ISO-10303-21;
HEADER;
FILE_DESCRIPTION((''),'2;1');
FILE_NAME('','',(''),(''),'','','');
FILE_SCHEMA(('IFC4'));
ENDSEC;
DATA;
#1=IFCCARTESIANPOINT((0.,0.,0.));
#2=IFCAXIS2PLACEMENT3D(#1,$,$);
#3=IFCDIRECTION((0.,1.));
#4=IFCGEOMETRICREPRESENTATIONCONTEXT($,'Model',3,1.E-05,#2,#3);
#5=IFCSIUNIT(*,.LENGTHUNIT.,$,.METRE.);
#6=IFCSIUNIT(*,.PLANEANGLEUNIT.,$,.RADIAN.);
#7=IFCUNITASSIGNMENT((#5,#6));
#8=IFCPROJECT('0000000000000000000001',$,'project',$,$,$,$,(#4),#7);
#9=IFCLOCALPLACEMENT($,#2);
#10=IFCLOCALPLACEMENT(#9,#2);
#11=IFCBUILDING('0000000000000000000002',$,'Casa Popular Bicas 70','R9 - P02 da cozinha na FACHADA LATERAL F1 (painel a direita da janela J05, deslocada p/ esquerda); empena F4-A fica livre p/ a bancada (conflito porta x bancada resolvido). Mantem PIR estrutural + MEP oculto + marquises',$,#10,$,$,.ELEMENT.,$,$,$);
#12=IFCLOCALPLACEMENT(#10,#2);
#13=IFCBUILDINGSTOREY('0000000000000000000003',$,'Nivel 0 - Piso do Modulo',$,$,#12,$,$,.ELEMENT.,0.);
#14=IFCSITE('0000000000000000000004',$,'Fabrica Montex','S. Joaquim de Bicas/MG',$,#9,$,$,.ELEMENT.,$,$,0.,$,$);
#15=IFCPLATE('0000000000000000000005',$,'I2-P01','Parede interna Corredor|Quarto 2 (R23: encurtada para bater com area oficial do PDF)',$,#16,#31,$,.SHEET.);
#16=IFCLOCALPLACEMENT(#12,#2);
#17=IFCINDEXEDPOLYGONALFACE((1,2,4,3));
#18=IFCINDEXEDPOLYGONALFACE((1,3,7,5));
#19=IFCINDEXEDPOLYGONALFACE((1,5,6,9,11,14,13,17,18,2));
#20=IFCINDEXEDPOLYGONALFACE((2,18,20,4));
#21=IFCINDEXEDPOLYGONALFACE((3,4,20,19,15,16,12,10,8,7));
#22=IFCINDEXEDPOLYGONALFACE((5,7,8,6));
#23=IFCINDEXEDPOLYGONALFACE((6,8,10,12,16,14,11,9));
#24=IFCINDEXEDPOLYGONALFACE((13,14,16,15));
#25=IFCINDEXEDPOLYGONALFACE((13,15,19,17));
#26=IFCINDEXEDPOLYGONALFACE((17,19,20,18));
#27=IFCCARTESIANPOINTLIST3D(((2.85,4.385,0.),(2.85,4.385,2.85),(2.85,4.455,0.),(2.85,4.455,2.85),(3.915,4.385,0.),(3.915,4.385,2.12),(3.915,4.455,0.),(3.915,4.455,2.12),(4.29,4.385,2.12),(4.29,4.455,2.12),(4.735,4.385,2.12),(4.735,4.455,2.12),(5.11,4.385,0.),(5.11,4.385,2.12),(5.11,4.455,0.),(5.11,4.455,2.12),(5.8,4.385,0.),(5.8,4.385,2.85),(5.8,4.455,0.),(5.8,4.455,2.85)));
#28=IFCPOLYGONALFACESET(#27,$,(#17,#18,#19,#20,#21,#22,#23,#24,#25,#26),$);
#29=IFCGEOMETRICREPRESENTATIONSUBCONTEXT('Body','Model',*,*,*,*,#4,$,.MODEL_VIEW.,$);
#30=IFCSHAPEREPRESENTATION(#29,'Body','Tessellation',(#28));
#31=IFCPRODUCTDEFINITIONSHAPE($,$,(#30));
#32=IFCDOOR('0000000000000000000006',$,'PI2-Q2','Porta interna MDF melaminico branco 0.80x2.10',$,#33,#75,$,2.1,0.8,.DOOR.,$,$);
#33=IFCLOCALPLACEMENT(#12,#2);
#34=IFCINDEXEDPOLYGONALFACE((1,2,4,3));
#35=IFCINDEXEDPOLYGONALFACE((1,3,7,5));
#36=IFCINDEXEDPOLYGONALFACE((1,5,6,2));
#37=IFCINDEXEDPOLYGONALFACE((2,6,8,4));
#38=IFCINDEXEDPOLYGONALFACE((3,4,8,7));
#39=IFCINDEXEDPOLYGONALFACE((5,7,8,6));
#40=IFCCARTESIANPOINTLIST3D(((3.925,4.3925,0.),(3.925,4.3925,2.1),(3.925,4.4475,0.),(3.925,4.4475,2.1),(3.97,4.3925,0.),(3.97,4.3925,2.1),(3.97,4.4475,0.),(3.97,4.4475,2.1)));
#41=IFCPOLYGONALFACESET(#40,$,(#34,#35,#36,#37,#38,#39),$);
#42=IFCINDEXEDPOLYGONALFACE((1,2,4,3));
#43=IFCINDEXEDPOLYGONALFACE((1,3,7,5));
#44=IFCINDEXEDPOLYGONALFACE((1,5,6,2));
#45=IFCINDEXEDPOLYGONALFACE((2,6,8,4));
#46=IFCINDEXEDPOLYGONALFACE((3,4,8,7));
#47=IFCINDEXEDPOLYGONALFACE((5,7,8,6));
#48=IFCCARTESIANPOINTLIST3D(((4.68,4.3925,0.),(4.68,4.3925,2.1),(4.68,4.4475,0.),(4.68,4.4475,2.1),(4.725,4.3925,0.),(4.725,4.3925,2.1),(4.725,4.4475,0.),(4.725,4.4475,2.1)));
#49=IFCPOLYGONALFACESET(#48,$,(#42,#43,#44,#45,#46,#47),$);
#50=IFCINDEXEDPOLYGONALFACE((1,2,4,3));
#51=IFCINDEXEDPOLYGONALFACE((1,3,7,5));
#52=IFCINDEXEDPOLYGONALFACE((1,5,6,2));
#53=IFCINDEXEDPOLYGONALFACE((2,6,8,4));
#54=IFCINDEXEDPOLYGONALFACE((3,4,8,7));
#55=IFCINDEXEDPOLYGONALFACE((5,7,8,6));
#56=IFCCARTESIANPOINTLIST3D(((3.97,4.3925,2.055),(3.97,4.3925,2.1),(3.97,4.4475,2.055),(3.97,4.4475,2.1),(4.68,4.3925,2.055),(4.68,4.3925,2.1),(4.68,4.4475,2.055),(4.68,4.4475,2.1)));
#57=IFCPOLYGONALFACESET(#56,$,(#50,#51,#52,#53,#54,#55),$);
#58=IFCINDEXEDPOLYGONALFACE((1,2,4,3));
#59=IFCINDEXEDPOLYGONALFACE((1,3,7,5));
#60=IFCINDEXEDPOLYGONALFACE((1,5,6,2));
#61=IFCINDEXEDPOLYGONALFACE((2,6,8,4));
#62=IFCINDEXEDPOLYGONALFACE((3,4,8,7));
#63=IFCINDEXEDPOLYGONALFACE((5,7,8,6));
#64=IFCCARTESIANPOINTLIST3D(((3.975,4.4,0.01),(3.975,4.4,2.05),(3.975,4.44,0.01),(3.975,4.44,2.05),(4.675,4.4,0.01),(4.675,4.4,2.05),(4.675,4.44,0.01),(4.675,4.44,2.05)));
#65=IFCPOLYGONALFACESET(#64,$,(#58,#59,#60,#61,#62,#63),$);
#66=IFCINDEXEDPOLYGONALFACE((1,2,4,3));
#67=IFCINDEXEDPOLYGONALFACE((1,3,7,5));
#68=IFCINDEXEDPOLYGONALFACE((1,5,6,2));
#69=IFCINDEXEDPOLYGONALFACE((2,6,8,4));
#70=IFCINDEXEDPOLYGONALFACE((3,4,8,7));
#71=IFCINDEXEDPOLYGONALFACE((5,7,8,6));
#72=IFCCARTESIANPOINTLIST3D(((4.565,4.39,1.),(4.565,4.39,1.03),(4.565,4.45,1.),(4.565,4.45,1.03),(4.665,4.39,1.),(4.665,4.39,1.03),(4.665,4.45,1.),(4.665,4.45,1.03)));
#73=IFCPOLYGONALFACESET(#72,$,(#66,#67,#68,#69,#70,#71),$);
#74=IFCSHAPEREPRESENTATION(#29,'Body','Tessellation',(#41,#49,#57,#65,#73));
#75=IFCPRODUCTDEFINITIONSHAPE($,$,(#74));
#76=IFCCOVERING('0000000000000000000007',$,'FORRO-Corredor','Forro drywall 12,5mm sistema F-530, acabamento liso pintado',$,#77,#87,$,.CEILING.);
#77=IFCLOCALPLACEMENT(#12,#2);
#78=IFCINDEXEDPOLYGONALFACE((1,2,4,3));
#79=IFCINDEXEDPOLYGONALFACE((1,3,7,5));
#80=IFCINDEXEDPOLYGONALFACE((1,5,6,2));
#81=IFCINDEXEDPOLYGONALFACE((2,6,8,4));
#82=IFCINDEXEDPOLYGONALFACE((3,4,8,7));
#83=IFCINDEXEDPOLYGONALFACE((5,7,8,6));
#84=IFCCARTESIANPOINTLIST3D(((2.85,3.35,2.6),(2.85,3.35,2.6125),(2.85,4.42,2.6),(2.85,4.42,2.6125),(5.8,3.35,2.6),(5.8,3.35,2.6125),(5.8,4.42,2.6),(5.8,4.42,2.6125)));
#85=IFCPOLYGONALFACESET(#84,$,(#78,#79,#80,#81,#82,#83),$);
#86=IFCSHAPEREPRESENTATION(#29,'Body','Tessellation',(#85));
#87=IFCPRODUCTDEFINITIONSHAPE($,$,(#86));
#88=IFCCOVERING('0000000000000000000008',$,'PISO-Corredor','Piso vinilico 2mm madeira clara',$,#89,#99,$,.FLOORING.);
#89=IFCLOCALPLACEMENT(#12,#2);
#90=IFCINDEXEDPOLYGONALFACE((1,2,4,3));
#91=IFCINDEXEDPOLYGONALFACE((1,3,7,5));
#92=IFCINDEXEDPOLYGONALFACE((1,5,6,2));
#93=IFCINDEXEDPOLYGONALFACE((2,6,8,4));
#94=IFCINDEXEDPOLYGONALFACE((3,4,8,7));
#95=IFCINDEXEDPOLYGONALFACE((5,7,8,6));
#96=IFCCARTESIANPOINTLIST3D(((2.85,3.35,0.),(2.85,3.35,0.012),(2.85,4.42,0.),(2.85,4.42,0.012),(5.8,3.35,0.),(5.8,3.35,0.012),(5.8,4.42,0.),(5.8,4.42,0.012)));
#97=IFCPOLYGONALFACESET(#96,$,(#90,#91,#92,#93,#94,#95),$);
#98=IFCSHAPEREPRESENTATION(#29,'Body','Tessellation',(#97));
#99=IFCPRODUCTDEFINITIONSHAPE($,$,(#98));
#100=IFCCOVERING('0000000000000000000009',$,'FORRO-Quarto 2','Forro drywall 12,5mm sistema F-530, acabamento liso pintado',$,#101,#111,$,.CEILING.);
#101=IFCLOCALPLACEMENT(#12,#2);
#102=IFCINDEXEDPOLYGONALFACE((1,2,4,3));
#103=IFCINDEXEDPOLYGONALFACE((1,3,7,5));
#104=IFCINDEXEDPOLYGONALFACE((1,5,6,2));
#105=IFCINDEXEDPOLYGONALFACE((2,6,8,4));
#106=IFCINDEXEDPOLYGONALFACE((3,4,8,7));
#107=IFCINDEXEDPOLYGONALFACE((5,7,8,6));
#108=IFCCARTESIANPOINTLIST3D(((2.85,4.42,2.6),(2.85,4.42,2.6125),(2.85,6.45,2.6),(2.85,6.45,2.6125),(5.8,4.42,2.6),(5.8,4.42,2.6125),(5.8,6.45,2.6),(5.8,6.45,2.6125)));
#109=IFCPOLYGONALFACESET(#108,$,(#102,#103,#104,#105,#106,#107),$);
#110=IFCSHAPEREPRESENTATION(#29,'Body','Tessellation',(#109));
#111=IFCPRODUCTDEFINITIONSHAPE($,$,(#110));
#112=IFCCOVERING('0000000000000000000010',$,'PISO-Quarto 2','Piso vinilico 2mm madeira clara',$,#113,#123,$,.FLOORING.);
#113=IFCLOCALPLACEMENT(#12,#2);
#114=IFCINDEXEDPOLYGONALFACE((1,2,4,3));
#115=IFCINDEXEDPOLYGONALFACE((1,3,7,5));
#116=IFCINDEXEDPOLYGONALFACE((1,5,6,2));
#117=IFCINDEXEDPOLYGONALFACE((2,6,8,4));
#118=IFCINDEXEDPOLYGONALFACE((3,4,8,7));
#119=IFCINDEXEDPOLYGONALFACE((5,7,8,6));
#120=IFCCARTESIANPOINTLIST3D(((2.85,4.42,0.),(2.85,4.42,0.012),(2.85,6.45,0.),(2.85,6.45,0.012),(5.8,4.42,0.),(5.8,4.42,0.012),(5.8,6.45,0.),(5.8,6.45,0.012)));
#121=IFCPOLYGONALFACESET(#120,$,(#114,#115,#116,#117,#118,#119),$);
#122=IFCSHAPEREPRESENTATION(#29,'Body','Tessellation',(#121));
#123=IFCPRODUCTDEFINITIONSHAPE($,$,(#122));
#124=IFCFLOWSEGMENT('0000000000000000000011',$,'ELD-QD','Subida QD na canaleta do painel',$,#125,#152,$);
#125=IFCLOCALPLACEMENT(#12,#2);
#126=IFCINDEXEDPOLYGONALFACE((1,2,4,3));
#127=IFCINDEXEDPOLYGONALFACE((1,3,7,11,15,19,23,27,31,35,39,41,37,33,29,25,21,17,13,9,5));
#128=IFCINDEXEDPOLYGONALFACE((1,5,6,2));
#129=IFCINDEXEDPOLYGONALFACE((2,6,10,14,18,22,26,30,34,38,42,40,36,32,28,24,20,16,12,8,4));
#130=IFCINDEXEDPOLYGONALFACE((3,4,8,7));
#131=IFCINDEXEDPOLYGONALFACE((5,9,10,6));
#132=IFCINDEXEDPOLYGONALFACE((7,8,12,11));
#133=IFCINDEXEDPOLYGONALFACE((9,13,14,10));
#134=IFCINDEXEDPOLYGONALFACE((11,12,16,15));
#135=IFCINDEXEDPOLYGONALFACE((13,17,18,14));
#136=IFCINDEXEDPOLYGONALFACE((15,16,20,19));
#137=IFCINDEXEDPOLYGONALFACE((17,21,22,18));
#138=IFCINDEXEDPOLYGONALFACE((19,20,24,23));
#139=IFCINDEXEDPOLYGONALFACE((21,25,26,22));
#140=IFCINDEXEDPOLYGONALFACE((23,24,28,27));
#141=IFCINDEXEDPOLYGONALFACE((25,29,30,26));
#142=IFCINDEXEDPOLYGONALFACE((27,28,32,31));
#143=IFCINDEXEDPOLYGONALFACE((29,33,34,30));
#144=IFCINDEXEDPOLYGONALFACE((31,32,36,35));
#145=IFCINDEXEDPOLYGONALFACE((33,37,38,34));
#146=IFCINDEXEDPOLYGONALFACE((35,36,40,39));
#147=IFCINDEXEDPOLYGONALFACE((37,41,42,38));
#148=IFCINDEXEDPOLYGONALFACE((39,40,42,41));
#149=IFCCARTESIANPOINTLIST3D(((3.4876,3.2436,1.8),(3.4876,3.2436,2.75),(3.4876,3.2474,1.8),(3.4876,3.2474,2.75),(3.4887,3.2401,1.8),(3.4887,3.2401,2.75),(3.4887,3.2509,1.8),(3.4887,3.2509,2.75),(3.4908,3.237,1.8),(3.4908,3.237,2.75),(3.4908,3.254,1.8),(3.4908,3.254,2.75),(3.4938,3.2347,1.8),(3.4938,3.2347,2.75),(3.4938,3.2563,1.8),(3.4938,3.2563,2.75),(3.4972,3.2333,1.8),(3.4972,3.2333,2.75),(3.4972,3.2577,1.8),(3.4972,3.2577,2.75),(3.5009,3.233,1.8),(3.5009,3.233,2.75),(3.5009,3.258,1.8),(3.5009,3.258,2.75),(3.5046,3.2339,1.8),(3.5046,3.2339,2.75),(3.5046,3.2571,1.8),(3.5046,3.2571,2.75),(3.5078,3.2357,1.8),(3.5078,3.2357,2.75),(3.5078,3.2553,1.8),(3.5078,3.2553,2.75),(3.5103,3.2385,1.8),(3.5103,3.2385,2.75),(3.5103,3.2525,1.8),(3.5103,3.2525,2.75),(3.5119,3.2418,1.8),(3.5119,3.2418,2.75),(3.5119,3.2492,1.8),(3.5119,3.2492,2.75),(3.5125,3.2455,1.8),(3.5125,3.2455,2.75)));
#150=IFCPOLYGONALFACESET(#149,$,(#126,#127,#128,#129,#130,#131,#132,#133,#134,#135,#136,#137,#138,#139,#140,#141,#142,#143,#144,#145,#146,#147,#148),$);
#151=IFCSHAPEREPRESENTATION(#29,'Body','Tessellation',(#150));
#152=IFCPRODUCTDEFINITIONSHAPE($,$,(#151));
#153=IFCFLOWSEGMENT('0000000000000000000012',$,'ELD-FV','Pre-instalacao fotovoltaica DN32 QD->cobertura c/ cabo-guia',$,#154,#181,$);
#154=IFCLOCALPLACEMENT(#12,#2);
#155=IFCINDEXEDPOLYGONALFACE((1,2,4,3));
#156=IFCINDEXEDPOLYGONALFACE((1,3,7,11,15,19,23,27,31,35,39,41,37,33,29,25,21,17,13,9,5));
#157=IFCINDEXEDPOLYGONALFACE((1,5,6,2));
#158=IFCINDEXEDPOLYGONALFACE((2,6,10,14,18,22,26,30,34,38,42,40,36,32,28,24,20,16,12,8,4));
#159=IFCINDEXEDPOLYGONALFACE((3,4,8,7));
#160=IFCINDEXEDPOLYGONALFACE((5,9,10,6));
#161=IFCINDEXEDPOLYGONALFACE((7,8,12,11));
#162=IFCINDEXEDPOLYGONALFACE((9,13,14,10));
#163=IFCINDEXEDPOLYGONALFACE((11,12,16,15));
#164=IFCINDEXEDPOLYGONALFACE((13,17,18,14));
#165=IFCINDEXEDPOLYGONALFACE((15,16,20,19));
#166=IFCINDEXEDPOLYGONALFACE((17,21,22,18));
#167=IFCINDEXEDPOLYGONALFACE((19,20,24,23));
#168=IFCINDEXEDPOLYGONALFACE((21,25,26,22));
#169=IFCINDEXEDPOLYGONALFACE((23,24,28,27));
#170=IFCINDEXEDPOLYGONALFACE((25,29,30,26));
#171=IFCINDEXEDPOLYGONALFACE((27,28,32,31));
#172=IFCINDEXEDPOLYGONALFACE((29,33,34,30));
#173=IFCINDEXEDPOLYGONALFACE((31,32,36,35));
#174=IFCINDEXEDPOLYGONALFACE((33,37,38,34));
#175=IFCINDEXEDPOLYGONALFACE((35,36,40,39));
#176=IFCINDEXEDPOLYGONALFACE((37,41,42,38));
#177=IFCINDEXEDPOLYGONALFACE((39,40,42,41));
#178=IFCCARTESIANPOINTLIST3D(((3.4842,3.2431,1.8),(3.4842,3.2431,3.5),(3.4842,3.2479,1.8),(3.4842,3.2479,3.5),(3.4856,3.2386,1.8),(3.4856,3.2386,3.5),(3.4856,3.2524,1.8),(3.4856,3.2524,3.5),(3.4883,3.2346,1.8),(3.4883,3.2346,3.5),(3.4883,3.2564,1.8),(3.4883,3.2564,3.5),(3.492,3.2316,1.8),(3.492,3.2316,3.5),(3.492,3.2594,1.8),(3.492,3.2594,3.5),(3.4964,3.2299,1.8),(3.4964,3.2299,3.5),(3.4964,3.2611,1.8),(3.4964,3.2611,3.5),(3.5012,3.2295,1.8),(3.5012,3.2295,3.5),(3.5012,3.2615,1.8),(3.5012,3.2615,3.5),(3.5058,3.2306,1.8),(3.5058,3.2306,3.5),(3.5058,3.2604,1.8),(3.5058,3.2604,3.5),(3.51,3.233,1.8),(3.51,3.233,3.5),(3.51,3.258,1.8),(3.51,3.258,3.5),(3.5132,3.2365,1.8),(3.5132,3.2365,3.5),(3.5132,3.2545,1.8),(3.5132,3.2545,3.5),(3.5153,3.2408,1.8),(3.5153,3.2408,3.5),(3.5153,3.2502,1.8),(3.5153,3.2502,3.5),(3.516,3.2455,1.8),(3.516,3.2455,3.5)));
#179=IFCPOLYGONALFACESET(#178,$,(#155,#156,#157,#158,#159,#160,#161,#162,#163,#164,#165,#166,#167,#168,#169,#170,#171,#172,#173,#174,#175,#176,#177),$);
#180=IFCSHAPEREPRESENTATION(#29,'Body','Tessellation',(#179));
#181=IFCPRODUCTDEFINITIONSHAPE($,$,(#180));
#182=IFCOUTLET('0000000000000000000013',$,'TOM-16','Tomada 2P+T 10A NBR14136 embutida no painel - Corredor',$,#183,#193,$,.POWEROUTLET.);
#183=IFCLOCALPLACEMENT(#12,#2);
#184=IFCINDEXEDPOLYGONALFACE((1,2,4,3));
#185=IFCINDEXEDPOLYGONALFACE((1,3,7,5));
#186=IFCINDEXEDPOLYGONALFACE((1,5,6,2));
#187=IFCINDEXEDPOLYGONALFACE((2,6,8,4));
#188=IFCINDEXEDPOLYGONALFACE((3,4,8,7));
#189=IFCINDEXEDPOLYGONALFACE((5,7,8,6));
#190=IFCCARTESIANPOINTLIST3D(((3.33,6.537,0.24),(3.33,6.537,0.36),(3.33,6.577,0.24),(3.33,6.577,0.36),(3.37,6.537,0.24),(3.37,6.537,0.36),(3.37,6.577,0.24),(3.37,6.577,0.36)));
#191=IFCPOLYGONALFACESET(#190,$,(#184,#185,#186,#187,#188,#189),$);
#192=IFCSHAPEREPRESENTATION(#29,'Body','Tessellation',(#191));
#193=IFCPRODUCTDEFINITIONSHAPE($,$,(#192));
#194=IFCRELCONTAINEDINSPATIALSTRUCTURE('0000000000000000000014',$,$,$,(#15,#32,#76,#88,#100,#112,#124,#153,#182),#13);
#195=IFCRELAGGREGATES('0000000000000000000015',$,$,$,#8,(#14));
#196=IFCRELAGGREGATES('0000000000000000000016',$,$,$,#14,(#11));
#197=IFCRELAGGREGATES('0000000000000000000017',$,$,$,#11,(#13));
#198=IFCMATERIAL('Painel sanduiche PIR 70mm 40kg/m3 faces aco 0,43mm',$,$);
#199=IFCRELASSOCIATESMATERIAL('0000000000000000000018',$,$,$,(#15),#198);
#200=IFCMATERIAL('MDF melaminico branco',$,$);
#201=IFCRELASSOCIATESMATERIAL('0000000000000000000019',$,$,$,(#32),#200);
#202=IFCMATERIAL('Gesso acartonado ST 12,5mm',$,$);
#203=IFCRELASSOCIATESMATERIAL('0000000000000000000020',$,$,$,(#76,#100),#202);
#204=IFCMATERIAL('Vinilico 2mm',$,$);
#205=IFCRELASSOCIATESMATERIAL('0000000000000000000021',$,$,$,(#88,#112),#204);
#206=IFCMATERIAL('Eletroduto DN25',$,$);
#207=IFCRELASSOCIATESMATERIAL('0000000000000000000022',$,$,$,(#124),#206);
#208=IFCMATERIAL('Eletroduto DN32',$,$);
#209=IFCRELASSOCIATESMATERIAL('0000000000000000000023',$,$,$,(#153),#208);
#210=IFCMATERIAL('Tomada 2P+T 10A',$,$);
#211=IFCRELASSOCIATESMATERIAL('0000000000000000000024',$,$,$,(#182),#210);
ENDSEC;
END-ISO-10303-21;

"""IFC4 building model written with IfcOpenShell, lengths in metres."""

from ifc_helpers import new_model, si_unit, direction, frame, frame_2d, origin, origin_2d, place, context, subcontext, project, spatial, rectangle, circle, extrude, material, element, fill, save


model = new_model("IFC4")

# Units and contexts
model_context = context("Model", 3, precision=1e-05, world=origin(), true_north=direction((0.0, 1.0)))
body_context = subcontext(model_context, "Body", "Model", "MODEL_VIEW")
ifc_project = project(units=[si_unit("LENGTHUNIT", "METRE"), si_unit("PLANEANGLEUNIT", "RADIAN")], contexts=[model_context])

# Site, building, storey
site_placement = place(None, origin())
site = spatial("IfcSite", under=ifc_project, at=site_placement, Name="Fabrica Montex", Description="S. Joaquim de Bicas/MG", CompositionType="ELEMENT", RefElevation=0.0)
building_placement = place(site_placement, origin())
building = spatial("IfcBuilding", under=site, at=building_placement, Name="Casa Popular Bicas 70", Description="R9 - P02 da cozinha na FACHADA LATERAL F1 (painel a direita da janela J05, deslocada p/ esquerda); empena F4-A fica livre p/ a bancada (conflito porta x bancada resolvido). Mantem PIR estrutural + MEP oculto + marquises", CompositionType="ELEMENT")
storey_placement = place(building_placement, origin())
storey = spatial("IfcBuildingStorey", under=building, at=storey_placement, Name="Nivel 0 - Piso do Modulo", CompositionType="ELEMENT", Elevation=0.0)

# Shared definitions
ifc_material_1 = material(Name="Painel sanduiche PIR 70mm 40kg/m3 faces aco 0,43mm")

# Shared definitions
ifc_material_2 = material(Name="MDF melaminico branco")

# Plate, openings, door
plate_1_placement = place(storey_placement, frame((2.85, 4.42, 0.0)))
plate_1 = element("IfcPlate", 1, at=plate_1_placement, inside=storey, material=ifc_material_1, Name="I2-P01", Description="Parede interna Corredor|Quarto 2 (R23: encurtada para bater com area oficial do PDF)", PredefinedType="SHEET", context=body_context, shape_type="SweptSolid", body=[
    extrude(rectangle(XDim=2.95, YDim=0.07, at=frame_2d((1.475, 0.0))), origin(), (0.0, 0.0, 1.0), 2.85),
])
opening_1_placement = place(storey_placement, frame((3.9, 3.575, 0.0), x_axis=(0.0, 1.0, 0.0)))
element("IfcOpeningElement", 2, at=opening_1_placement, cuts=plate_1, PredefinedType="OPENING", context=body_context, shape_type="SweptSolid", body=[
    extrude(rectangle(XDim=0.82, YDim=0.3, at=frame_2d((0.4, 0.0))), origin(), (0.0, 0.0, 1.0), 2.12),
])
opening_2_placement = place(storey_placement, frame((4.3, 4.42, 0.0)))
element("IfcOpeningElement", 3, at=opening_2_placement, cuts=plate_1, PredefinedType="OPENING", context=body_context, shape_type="SweptSolid", body=[
    extrude(rectangle(XDim=0.82, YDim=0.3, at=frame_2d((0.4, 0.0))), origin(), (0.0, 0.0, 1.0), 2.12),
])
opening_3_placement = place(storey_placement, frame((3.925, 4.42, 0.0)))
opening_3 = element("IfcOpeningElement", 4, at=opening_3_placement, cuts=plate_1, PredefinedType="OPENING", context=body_context, shape_type="SweptSolid", body=[
    extrude(rectangle(XDim=0.82, YDim=0.3, at=frame_2d((0.4, 0.0))), origin(), (0.0, 0.0, 1.0), 2.12),
])
door_1_placement = place(storey_placement, frame((3.925, 4.42, 0.0)))
door_1 = element("IfcDoor", 5, at=door_1_placement, inside=storey, material=ifc_material_2, Name="PI2-Q2", Description="Porta interna MDF melaminico branco 0.80x2.10", OverallHeight=2.1, OverallWidth=0.8, PredefinedType="DOOR", context=body_context, shape_type="SweptSolid", body=[
    extrude(rectangle(XDim=0.045, YDim=0.055, at=frame_2d((0.0225, 0.0))), origin(), (0.0, 0.0, 1.0), 2.1),
    extrude(rectangle(XDim=0.045, YDim=0.055, at=frame_2d((0.7775, 0.0))), origin(), (0.0, 0.0, 1.0), 2.1),
    extrude(rectangle(XDim=0.71, YDim=0.055, at=frame_2d((0.4, 0.0))), frame((0.0, 0.0, 2.055)), (0.0, 0.0, 1.0), 0.045),
    extrude(rectangle(XDim=0.7, YDim=0.04, at=frame_2d((0.4, 0.0))), frame((0.0, 0.0, 0.01)), (0.0, 0.0, 1.0), 2.04),
    extrude(rectangle(XDim=0.1, YDim=0.06, at=frame_2d((0.69, 0.0))), frame((0.0, 0.0, 1.0)), (0.0, 0.0, 1.0), 0.03),
])
fill(opening_3, door_1)

# Coverings
ifc_material_3 = material(Name="Gesso acartonado ST 12,5mm")
covering_1_placement = place(storey_placement, frame((2.85, 3.35, 2.6)))
element("IfcCovering", 6, at=covering_1_placement, inside=storey, material=ifc_material_3, Name="FORRO-Corredor", Description="Forro drywall 12,5mm sistema F-530, acabamento liso pintado", PredefinedType="CEILING", context=body_context, shape_type="SweptSolid", body=[
    extrude(rectangle(XDim=2.95, YDim=1.07, at=frame_2d((1.475, 0.535))), origin(), (0.0, 0.0, 1.0), 0.0125),
])
ifc_material_4 = material(Name="Vinilico 2mm")
covering_2_placement = place(storey_placement, frame((2.85, 3.35, 0.0)))
element("IfcCovering", 7, at=covering_2_placement, inside=storey, material=ifc_material_4, Name="PISO-Corredor", Description="Piso vinilico 2mm madeira clara", PredefinedType="FLOORING", context=body_context, shape_type="SweptSolid", body=[
    extrude(rectangle(XDim=2.95, YDim=1.07, at=frame_2d((1.475, 0.535))), origin(), (0.0, 0.0, 1.0), 0.012),
])
covering_3_placement = place(storey_placement, frame((2.85, 4.42, 2.6)))
element("IfcCovering", 8, at=covering_3_placement, inside=storey, material=ifc_material_3, Name="FORRO-Quarto 2", Description="Forro drywall 12,5mm sistema F-530, acabamento liso pintado", PredefinedType="CEILING", context=body_context, shape_type="SweptSolid", body=[
    extrude(rectangle(XDim=2.95, YDim=2.03, at=frame_2d((1.475, 1.015))), origin(), (0.0, 0.0, 1.0), 0.0125),
])
covering_4_placement = place(storey_placement, frame((2.85, 4.42, 0.0)))
element("IfcCovering", 9, at=covering_4_placement, inside=storey, material=ifc_material_4, Name="PISO-Quarto 2", Description="Piso vinilico 2mm madeira clara", PredefinedType="FLOORING", context=body_context, shape_type="SweptSolid", body=[
    extrude(rectangle(XDim=2.95, YDim=2.03, at=frame_2d((1.475, 1.015))), origin(), (0.0, 0.0, 1.0), 0.012),
])

# Flow segments
ifc_material_5 = material(Name="Eletroduto DN25")
flow_segment_1_placement = place(storey_placement, frame((3.5, 3.2455, 1.8), z_axis=(0.0, 0.0, 1.0), x_axis=(1.0, 0.0, 0.0)))
element("IfcFlowSegment", 10, at=flow_segment_1_placement, inside=storey, material=ifc_material_5, Name="ELD-QD", Description="Subida QD na canaleta do painel", context=body_context, shape_type="SweptSolid", body=[
    extrude(circle(Radius=0.0125, at=origin_2d()), origin(), (0.0, 0.0, 1.0), 0.95),
])
ifc_material_6 = material(Name="Eletroduto DN32")
flow_segment_2_placement = place(storey_placement, frame((3.5, 3.2455, 1.8), z_axis=(0.0, 0.0, 1.0), x_axis=(1.0, 0.0, 0.0)))
element("IfcFlowSegment", 11, at=flow_segment_2_placement, inside=storey, material=ifc_material_6, Name="ELD-FV", Description="Pre-instalacao fotovoltaica DN32 QD->cobertura c/ cabo-guia", context=body_context, shape_type="SweptSolid", body=[
    extrude(circle(Radius=0.016, at=origin_2d()), origin(), (0.0, 0.0, 1.0), 1.7),
])

# Outlet
ifc_material_7 = material(Name="Tomada 2P+T 10A")
outlet_1_placement = place(storey_placement, frame((3.33, 6.537, 0.24)))
element("IfcOutlet", 12, at=outlet_1_placement, inside=storey, material=ifc_material_7, Name="TOM-16", Description="Tomada 2P+T 10A NBR14136 embutida no painel - Corredor", PredefinedType="POWEROUTLET", context=body_context, shape_type="SweptSolid", body=[
    extrude(rectangle(XDim=0.04, YDim=0.04, at=frame_2d((0.02, 0.02))), origin(), (0.0, 0.0, 1.0), 0.12),
])

save(model, "model.ifc")
